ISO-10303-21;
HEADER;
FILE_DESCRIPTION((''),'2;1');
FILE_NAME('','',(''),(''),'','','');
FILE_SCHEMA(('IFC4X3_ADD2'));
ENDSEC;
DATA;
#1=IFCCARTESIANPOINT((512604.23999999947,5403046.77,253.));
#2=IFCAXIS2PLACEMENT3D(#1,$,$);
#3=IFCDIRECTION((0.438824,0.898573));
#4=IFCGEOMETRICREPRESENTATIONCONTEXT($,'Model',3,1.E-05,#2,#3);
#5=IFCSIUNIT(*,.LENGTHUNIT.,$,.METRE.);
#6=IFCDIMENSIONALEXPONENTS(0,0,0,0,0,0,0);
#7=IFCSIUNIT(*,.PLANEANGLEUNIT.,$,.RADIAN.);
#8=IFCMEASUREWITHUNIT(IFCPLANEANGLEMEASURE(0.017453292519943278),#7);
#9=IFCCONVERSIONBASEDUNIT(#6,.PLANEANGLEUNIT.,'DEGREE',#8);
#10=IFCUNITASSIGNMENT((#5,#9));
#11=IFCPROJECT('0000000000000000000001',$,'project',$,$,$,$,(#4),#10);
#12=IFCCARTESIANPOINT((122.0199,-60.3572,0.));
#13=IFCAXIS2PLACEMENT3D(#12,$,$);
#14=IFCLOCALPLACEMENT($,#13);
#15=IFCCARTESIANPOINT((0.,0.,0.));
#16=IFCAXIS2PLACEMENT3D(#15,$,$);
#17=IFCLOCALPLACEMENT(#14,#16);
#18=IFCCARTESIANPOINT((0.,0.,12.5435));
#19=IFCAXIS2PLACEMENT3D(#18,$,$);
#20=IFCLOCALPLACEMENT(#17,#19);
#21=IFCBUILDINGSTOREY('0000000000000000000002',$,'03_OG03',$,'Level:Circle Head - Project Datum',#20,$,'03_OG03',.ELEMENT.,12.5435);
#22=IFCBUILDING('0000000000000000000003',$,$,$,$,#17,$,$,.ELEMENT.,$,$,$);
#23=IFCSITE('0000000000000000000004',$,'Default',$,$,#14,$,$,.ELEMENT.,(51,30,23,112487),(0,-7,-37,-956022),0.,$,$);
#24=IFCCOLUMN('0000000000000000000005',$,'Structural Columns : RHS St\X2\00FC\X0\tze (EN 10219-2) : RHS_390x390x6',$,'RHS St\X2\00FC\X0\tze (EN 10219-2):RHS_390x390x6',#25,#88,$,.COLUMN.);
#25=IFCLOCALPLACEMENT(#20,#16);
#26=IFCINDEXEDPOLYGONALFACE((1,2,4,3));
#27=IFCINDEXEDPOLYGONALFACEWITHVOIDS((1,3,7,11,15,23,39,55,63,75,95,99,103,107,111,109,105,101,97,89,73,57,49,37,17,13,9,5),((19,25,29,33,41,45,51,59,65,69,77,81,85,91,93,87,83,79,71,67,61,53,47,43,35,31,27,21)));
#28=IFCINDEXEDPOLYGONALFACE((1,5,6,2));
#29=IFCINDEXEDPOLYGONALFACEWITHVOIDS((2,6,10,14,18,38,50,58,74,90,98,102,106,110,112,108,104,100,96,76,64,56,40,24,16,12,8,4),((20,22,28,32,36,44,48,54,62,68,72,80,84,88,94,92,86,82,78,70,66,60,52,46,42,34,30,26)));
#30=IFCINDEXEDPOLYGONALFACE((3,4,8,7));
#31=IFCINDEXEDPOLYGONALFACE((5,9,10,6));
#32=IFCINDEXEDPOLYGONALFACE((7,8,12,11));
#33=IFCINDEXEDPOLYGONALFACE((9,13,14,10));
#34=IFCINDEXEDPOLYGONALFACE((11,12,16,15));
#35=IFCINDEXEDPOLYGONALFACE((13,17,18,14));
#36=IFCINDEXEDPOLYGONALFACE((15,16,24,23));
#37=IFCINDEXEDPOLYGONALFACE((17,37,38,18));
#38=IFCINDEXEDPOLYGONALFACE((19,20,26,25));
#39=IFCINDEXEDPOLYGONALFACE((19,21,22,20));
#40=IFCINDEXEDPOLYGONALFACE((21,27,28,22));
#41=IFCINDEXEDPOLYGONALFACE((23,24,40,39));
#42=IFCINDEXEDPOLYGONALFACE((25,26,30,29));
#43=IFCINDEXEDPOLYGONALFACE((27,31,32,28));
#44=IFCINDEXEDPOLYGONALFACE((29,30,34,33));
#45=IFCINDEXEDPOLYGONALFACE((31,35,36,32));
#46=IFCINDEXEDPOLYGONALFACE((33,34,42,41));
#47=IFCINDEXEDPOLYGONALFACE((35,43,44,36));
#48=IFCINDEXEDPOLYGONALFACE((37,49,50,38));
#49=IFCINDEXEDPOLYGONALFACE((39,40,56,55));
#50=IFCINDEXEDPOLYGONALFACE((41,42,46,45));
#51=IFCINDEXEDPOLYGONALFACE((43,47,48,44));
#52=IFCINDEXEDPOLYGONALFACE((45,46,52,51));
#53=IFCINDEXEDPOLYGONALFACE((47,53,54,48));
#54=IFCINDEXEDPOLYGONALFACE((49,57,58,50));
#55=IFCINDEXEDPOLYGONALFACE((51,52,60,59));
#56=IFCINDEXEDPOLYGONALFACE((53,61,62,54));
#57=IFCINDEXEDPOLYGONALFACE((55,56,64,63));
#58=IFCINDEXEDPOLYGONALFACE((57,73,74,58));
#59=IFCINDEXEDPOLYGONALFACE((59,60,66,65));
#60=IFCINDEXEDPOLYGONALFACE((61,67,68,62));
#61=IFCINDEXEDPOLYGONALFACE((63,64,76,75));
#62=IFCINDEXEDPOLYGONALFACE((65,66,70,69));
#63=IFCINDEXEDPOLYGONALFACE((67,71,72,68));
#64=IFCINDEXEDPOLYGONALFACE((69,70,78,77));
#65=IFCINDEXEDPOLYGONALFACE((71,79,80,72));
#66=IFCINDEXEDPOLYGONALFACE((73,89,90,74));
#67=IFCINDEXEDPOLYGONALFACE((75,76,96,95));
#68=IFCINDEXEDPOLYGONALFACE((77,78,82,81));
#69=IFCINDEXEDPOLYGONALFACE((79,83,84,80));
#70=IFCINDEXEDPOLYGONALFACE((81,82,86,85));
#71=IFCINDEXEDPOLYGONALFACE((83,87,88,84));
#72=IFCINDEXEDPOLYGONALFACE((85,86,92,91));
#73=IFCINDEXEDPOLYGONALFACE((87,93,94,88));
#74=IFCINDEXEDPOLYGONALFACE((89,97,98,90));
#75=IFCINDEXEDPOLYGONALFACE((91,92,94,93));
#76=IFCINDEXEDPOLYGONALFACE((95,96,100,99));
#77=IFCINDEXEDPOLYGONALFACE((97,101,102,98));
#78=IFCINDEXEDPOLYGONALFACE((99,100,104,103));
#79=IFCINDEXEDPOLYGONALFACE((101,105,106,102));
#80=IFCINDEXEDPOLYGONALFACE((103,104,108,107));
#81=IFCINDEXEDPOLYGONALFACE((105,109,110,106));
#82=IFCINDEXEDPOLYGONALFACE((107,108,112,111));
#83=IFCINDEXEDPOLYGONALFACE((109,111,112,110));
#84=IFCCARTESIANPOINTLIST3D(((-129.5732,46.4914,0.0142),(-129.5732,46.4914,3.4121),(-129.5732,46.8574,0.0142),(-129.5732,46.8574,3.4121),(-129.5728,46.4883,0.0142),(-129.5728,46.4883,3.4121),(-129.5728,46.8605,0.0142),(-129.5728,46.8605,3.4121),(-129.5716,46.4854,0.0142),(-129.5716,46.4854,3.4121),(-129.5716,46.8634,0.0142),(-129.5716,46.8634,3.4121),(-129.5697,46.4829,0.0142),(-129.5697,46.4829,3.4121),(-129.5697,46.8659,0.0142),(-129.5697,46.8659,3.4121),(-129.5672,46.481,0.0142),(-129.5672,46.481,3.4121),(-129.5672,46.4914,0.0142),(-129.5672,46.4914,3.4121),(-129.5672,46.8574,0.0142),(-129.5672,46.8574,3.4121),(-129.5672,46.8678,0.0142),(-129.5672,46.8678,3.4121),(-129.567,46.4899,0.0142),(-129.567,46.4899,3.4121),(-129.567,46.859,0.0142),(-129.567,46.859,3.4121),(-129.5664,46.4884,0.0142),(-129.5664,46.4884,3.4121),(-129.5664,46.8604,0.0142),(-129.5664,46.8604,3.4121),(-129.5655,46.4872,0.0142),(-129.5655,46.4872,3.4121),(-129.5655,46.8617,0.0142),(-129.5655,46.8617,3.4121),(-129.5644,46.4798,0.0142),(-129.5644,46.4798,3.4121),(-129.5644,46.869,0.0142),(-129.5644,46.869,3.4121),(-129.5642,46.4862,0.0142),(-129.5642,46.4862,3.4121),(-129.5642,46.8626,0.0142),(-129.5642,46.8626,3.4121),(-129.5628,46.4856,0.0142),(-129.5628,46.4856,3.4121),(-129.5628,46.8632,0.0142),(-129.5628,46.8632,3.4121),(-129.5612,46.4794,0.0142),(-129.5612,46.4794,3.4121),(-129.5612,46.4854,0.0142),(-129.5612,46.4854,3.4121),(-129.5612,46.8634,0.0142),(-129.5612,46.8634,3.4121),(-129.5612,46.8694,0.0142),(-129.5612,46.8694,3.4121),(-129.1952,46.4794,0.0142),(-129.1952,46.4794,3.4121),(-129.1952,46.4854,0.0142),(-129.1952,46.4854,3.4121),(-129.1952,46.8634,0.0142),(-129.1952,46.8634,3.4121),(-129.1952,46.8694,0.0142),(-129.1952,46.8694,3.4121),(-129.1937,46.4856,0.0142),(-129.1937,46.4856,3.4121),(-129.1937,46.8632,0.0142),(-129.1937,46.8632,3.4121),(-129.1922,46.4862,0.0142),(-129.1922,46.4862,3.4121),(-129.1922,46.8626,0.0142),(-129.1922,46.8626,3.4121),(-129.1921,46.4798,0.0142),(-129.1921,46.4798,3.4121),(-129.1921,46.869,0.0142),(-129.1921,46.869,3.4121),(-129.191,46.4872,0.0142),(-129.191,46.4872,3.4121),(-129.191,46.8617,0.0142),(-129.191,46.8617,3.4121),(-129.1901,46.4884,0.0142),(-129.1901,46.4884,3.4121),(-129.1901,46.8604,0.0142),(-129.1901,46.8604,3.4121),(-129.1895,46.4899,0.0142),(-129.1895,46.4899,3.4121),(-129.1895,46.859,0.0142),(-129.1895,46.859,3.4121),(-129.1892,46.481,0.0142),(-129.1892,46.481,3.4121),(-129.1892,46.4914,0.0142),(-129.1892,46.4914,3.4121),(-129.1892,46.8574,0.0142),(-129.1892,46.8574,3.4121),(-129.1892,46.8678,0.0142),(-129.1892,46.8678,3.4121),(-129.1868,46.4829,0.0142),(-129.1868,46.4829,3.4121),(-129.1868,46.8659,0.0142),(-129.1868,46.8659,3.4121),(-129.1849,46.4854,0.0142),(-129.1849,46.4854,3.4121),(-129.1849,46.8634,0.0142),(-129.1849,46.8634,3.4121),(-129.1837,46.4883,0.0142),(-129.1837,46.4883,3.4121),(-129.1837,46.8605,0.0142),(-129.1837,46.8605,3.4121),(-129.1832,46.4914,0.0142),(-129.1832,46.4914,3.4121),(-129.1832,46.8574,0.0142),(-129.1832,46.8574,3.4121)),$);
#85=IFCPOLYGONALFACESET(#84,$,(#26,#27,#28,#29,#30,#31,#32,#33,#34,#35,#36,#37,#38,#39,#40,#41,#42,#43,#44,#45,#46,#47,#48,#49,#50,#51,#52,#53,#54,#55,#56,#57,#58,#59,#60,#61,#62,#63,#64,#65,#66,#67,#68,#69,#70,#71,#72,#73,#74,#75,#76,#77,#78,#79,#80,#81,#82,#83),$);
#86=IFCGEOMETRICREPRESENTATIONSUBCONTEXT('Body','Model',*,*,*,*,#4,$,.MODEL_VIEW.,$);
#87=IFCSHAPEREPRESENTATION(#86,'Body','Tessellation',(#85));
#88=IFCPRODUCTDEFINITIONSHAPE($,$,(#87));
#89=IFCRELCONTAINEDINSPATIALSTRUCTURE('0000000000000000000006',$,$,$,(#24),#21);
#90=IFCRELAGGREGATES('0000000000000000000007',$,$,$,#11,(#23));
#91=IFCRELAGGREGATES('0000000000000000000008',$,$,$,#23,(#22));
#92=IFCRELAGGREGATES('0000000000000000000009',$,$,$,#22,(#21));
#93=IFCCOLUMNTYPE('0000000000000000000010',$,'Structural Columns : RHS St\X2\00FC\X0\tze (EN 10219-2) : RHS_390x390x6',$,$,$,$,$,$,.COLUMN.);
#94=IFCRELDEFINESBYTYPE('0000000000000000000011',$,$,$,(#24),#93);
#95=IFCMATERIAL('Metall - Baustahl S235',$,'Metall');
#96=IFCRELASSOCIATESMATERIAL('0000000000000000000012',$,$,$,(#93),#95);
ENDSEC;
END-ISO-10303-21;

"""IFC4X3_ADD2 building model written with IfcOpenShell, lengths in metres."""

from ifc_helpers import new_model, entity, si_unit, converted_unit, direction, frame, frame_2d, origin, place, context, subcontext, project, spatial, polyline, circle_curve, parameter, trimmed, segment, composite_curve, outline, extrude, source, transform, mapped, material, material_profile, profile_set, type_object, type_shapes, element, save


model = new_model("IFC4X3_ADD2")

# Units and contexts
model_context = context("Model", 3, precision=1e-05, world=frame((512604.23999999947, 5403046.77, 253.0)), true_north=direction((0.438824, 0.898573)))
body_context = subcontext(model_context, "Body", "Model", "MODEL_VIEW")
ifc_project = project(units=[si_unit("LENGTHUNIT", "METRE"), converted_unit("PLANEANGLEUNIT", "DEGREE", entity("IfcPlaneAngleMeasure", 0.017453292519943278), si_unit("PLANEANGLEUNIT", "RADIAN"), dimensions=[0, 0, 0, 0, 0, 0, 0])], contexts=[model_context])

# Site, building, storey
site_placement = place(None, frame((122.0199, -60.3572, 0.0)))
site = spatial("IfcSite", under=ifc_project, at=site_placement, Name="Default", CompositionType="ELEMENT", RefLatitude=(51, 30, 23, 112487), RefLongitude=(0, -7, -37, -956022), RefElevation=0.0)
building_placement = place(site_placement, origin())
building = spatial("IfcBuilding", under=site, at=building_placement, CompositionType="ELEMENT")
storey_placement = place(building_placement, frame((0.0, 0.0, 12.5435)))
storey = spatial("IfcBuildingStorey", under=building, at=storey_placement, Name="03_OG03", ObjectType="Level:Circle Head - Project Datum", LongName="03_OG03", CompositionType="ELEMENT", Elevation=12.5435)

# Column
ifc_material_1 = material(Name="Metall - Baustahl S235", Category="Metall")
ifc_material_profile = material_profile(ifc_material_1, outline(composite_curve([segment(polyline([(-0.183, -0.195), (0.183, -0.195)]), True, "CONTINUOUS"), segment(trimmed(circle_curve(frame_2d((0.183, -0.183), x_axis=(-1.0, 0.0)), 0.012), [parameter(90.0)], [parameter(180.0)], True, "PARAMETER"), True, "CONTINUOUS"), segment(polyline([(0.195, -0.183), (0.195, 0.183)]), True, "CONTINUOUS"), segment(trimmed(circle_curve(frame_2d((0.183, 0.183), x_axis=(-1.0, 0.0)), 0.012), [parameter(180.0)], [parameter(270.0)], True, "PARAMETER"), True, "CONTINUOUS"), segment(polyline([(0.183, 0.195), (-0.183, 0.195)]), True, "CONTINUOUS"), segment(trimmed(circle_curve(frame_2d((-0.183, 0.183), x_axis=(-1.0, 0.0)), 0.012), [parameter(270.0)], [parameter(360.0)], True, "PARAMETER"), True, "CONTINUOUS"), segment(polyline([(-0.195, 0.183), (-0.195, -0.183)]), True, "CONTINUOUS"), segment(trimmed(circle_curve(frame_2d((-0.183, -0.183), x_axis=(-1.0, 0.0)), 0.012), [parameter(360.0)], [parameter(90.0)], True, "PARAMETER"), True, "CONTINUOUS")], self_intersect=False), holes=[composite_curve([segment(trimmed(circle_curve(frame_2d((-0.183, -0.183), x_axis=(-1.0, 0.0)), 0.006), [parameter(0.0)], [parameter(90.0)], True, "PARAMETER"), False, "CONTINUOUS"), segment(polyline([(-0.189, -0.183), (-0.189, 0.183)]), True, "CONTINUOUS"), segment(trimmed(circle_curve(frame_2d((-0.183, 0.183), x_axis=(-1.0, 0.0)), 0.006), [parameter(270.0)], [parameter(0.0)], True, "PARAMETER"), False, "CONTINUOUS"), segment(polyline([(-0.183, 0.189), (0.183, 0.189)]), True, "CONTINUOUS"), segment(trimmed(circle_curve(frame_2d((0.183, 0.183), x_axis=(-1.0, 0.0)), 0.006), [parameter(180.0)], [parameter(270.0)], True, "PARAMETER"), False, "CONTINUOUS"), segment(polyline([(0.189, 0.183), (0.189, -0.183)]), True, "CONTINUOUS"), segment(trimmed(circle_curve(frame_2d((0.183, -0.183), x_axis=(-1.0, 0.0)), 0.006), [parameter(90.0)], [parameter(180.0)], True, "PARAMETER"), False, "CONTINUOUS"), segment(polyline([(0.183, -0.189), (-0.183, -0.189)]), True, "CONTINUOUS")], self_intersect=False)]), Name="RHS_390x390x6")
ifc_profile_set = profile_set([ifc_material_profile], Name="RHS_390x390x6")
column_type_1 = type_object("IfcColumnType", Name="Structural Columns : RHS Stütze (EN 10219-2) : RHS_390x390x6", PredefinedType="COLUMN", material=ifc_profile_set)
shared_shape_1 = source(origin(), body_context, "Body", "SweptSolid", [
    extrude(outline(composite_curve([segment(polyline([(-0.183, -0.195), (0.183, -0.195)]), True, "CONTINUOUS"), segment(trimmed(circle_curve(frame_2d((0.183, -0.183), x_axis=(-1.0, 0.0)), 0.012), [parameter(90.0)], [parameter(180.0)], True, "PARAMETER"), True, "CONTINUOUS"), segment(polyline([(0.195, -0.183), (0.195, 0.183)]), True, "CONTINUOUS"), segment(trimmed(circle_curve(frame_2d((0.183, 0.183), x_axis=(-1.0, 0.0)), 0.012), [parameter(180.0)], [parameter(270.0)], True, "PARAMETER"), True, "CONTINUOUS"), segment(polyline([(0.183, 0.195), (-0.183, 0.195)]), True, "CONTINUOUS"), segment(trimmed(circle_curve(frame_2d((-0.183, 0.183), x_axis=(-1.0, 0.0)), 0.012), [parameter(270.0)], [parameter(360.0)], True, "PARAMETER"), True, "CONTINUOUS"), segment(polyline([(-0.195, 0.183), (-0.195, -0.183)]), True, "CONTINUOUS"), segment(trimmed(circle_curve(frame_2d((-0.183, -0.183), x_axis=(-1.0, 0.0)), 0.012), [parameter(360.0)], [parameter(90.0)], True, "PARAMETER"), True, "CONTINUOUS")], self_intersect=False), holes=[composite_curve([segment(trimmed(circle_curve(frame_2d((-0.183, -0.183), x_axis=(-1.0, 0.0)), 0.006), [parameter(0.0)], [parameter(90.0)], True, "PARAMETER"), False, "CONTINUOUS"), segment(polyline([(-0.189, -0.183), (-0.189, 0.183)]), True, "CONTINUOUS"), segment(trimmed(circle_curve(frame_2d((-0.183, 0.183), x_axis=(-1.0, 0.0)), 0.006), [parameter(270.0)], [parameter(0.0)], True, "PARAMETER"), False, "CONTINUOUS"), segment(polyline([(-0.183, 0.189), (0.183, 0.189)]), True, "CONTINUOUS"), segment(trimmed(circle_curve(frame_2d((0.183, 0.183), x_axis=(-1.0, 0.0)), 0.006), [parameter(180.0)], [parameter(270.0)], True, "PARAMETER"), False, "CONTINUOUS"), segment(polyline([(0.189, 0.183), (0.189, -0.183)]), True, "CONTINUOUS"), segment(trimmed(circle_curve(frame_2d((0.183, -0.183), x_axis=(-1.0, 0.0)), 0.006), [parameter(90.0)], [parameter(180.0)], True, "PARAMETER"), False, "CONTINUOUS"), segment(polyline([(0.183, -0.189), (-0.183, -0.189)]), True, "CONTINUOUS")], self_intersect=False)]), frame((0.0, 0.0, 12.5577), z_axis=(0.0, 0.0, 1.0), x_axis=(-1.0, 0.0, 0.0)), (0.0, 0.0, 1.0), 3.3979),
])
type_shapes(column_type_1, [shared_shape_1])
column_1_placement = place(storey_placement, frame((-129.3782, 46.6744, -12.5435)))
element("IfcColumn", 1, at=column_1_placement, inside=storey, type_object=column_type_1, Name="Structural Columns : RHS Stütze (EN 10219-2) : RHS_390x390x6", ObjectType="RHS Stütze (EN 10219-2):RHS_390x390x6", PredefinedType="COLUMN", context=body_context, shape_type="MappedRepresentation", body=[
    mapped(shared_shape_1, transform((0.0, 0.0, 0.0), scale=1.0)),
])

save(model, "model.ifc")
